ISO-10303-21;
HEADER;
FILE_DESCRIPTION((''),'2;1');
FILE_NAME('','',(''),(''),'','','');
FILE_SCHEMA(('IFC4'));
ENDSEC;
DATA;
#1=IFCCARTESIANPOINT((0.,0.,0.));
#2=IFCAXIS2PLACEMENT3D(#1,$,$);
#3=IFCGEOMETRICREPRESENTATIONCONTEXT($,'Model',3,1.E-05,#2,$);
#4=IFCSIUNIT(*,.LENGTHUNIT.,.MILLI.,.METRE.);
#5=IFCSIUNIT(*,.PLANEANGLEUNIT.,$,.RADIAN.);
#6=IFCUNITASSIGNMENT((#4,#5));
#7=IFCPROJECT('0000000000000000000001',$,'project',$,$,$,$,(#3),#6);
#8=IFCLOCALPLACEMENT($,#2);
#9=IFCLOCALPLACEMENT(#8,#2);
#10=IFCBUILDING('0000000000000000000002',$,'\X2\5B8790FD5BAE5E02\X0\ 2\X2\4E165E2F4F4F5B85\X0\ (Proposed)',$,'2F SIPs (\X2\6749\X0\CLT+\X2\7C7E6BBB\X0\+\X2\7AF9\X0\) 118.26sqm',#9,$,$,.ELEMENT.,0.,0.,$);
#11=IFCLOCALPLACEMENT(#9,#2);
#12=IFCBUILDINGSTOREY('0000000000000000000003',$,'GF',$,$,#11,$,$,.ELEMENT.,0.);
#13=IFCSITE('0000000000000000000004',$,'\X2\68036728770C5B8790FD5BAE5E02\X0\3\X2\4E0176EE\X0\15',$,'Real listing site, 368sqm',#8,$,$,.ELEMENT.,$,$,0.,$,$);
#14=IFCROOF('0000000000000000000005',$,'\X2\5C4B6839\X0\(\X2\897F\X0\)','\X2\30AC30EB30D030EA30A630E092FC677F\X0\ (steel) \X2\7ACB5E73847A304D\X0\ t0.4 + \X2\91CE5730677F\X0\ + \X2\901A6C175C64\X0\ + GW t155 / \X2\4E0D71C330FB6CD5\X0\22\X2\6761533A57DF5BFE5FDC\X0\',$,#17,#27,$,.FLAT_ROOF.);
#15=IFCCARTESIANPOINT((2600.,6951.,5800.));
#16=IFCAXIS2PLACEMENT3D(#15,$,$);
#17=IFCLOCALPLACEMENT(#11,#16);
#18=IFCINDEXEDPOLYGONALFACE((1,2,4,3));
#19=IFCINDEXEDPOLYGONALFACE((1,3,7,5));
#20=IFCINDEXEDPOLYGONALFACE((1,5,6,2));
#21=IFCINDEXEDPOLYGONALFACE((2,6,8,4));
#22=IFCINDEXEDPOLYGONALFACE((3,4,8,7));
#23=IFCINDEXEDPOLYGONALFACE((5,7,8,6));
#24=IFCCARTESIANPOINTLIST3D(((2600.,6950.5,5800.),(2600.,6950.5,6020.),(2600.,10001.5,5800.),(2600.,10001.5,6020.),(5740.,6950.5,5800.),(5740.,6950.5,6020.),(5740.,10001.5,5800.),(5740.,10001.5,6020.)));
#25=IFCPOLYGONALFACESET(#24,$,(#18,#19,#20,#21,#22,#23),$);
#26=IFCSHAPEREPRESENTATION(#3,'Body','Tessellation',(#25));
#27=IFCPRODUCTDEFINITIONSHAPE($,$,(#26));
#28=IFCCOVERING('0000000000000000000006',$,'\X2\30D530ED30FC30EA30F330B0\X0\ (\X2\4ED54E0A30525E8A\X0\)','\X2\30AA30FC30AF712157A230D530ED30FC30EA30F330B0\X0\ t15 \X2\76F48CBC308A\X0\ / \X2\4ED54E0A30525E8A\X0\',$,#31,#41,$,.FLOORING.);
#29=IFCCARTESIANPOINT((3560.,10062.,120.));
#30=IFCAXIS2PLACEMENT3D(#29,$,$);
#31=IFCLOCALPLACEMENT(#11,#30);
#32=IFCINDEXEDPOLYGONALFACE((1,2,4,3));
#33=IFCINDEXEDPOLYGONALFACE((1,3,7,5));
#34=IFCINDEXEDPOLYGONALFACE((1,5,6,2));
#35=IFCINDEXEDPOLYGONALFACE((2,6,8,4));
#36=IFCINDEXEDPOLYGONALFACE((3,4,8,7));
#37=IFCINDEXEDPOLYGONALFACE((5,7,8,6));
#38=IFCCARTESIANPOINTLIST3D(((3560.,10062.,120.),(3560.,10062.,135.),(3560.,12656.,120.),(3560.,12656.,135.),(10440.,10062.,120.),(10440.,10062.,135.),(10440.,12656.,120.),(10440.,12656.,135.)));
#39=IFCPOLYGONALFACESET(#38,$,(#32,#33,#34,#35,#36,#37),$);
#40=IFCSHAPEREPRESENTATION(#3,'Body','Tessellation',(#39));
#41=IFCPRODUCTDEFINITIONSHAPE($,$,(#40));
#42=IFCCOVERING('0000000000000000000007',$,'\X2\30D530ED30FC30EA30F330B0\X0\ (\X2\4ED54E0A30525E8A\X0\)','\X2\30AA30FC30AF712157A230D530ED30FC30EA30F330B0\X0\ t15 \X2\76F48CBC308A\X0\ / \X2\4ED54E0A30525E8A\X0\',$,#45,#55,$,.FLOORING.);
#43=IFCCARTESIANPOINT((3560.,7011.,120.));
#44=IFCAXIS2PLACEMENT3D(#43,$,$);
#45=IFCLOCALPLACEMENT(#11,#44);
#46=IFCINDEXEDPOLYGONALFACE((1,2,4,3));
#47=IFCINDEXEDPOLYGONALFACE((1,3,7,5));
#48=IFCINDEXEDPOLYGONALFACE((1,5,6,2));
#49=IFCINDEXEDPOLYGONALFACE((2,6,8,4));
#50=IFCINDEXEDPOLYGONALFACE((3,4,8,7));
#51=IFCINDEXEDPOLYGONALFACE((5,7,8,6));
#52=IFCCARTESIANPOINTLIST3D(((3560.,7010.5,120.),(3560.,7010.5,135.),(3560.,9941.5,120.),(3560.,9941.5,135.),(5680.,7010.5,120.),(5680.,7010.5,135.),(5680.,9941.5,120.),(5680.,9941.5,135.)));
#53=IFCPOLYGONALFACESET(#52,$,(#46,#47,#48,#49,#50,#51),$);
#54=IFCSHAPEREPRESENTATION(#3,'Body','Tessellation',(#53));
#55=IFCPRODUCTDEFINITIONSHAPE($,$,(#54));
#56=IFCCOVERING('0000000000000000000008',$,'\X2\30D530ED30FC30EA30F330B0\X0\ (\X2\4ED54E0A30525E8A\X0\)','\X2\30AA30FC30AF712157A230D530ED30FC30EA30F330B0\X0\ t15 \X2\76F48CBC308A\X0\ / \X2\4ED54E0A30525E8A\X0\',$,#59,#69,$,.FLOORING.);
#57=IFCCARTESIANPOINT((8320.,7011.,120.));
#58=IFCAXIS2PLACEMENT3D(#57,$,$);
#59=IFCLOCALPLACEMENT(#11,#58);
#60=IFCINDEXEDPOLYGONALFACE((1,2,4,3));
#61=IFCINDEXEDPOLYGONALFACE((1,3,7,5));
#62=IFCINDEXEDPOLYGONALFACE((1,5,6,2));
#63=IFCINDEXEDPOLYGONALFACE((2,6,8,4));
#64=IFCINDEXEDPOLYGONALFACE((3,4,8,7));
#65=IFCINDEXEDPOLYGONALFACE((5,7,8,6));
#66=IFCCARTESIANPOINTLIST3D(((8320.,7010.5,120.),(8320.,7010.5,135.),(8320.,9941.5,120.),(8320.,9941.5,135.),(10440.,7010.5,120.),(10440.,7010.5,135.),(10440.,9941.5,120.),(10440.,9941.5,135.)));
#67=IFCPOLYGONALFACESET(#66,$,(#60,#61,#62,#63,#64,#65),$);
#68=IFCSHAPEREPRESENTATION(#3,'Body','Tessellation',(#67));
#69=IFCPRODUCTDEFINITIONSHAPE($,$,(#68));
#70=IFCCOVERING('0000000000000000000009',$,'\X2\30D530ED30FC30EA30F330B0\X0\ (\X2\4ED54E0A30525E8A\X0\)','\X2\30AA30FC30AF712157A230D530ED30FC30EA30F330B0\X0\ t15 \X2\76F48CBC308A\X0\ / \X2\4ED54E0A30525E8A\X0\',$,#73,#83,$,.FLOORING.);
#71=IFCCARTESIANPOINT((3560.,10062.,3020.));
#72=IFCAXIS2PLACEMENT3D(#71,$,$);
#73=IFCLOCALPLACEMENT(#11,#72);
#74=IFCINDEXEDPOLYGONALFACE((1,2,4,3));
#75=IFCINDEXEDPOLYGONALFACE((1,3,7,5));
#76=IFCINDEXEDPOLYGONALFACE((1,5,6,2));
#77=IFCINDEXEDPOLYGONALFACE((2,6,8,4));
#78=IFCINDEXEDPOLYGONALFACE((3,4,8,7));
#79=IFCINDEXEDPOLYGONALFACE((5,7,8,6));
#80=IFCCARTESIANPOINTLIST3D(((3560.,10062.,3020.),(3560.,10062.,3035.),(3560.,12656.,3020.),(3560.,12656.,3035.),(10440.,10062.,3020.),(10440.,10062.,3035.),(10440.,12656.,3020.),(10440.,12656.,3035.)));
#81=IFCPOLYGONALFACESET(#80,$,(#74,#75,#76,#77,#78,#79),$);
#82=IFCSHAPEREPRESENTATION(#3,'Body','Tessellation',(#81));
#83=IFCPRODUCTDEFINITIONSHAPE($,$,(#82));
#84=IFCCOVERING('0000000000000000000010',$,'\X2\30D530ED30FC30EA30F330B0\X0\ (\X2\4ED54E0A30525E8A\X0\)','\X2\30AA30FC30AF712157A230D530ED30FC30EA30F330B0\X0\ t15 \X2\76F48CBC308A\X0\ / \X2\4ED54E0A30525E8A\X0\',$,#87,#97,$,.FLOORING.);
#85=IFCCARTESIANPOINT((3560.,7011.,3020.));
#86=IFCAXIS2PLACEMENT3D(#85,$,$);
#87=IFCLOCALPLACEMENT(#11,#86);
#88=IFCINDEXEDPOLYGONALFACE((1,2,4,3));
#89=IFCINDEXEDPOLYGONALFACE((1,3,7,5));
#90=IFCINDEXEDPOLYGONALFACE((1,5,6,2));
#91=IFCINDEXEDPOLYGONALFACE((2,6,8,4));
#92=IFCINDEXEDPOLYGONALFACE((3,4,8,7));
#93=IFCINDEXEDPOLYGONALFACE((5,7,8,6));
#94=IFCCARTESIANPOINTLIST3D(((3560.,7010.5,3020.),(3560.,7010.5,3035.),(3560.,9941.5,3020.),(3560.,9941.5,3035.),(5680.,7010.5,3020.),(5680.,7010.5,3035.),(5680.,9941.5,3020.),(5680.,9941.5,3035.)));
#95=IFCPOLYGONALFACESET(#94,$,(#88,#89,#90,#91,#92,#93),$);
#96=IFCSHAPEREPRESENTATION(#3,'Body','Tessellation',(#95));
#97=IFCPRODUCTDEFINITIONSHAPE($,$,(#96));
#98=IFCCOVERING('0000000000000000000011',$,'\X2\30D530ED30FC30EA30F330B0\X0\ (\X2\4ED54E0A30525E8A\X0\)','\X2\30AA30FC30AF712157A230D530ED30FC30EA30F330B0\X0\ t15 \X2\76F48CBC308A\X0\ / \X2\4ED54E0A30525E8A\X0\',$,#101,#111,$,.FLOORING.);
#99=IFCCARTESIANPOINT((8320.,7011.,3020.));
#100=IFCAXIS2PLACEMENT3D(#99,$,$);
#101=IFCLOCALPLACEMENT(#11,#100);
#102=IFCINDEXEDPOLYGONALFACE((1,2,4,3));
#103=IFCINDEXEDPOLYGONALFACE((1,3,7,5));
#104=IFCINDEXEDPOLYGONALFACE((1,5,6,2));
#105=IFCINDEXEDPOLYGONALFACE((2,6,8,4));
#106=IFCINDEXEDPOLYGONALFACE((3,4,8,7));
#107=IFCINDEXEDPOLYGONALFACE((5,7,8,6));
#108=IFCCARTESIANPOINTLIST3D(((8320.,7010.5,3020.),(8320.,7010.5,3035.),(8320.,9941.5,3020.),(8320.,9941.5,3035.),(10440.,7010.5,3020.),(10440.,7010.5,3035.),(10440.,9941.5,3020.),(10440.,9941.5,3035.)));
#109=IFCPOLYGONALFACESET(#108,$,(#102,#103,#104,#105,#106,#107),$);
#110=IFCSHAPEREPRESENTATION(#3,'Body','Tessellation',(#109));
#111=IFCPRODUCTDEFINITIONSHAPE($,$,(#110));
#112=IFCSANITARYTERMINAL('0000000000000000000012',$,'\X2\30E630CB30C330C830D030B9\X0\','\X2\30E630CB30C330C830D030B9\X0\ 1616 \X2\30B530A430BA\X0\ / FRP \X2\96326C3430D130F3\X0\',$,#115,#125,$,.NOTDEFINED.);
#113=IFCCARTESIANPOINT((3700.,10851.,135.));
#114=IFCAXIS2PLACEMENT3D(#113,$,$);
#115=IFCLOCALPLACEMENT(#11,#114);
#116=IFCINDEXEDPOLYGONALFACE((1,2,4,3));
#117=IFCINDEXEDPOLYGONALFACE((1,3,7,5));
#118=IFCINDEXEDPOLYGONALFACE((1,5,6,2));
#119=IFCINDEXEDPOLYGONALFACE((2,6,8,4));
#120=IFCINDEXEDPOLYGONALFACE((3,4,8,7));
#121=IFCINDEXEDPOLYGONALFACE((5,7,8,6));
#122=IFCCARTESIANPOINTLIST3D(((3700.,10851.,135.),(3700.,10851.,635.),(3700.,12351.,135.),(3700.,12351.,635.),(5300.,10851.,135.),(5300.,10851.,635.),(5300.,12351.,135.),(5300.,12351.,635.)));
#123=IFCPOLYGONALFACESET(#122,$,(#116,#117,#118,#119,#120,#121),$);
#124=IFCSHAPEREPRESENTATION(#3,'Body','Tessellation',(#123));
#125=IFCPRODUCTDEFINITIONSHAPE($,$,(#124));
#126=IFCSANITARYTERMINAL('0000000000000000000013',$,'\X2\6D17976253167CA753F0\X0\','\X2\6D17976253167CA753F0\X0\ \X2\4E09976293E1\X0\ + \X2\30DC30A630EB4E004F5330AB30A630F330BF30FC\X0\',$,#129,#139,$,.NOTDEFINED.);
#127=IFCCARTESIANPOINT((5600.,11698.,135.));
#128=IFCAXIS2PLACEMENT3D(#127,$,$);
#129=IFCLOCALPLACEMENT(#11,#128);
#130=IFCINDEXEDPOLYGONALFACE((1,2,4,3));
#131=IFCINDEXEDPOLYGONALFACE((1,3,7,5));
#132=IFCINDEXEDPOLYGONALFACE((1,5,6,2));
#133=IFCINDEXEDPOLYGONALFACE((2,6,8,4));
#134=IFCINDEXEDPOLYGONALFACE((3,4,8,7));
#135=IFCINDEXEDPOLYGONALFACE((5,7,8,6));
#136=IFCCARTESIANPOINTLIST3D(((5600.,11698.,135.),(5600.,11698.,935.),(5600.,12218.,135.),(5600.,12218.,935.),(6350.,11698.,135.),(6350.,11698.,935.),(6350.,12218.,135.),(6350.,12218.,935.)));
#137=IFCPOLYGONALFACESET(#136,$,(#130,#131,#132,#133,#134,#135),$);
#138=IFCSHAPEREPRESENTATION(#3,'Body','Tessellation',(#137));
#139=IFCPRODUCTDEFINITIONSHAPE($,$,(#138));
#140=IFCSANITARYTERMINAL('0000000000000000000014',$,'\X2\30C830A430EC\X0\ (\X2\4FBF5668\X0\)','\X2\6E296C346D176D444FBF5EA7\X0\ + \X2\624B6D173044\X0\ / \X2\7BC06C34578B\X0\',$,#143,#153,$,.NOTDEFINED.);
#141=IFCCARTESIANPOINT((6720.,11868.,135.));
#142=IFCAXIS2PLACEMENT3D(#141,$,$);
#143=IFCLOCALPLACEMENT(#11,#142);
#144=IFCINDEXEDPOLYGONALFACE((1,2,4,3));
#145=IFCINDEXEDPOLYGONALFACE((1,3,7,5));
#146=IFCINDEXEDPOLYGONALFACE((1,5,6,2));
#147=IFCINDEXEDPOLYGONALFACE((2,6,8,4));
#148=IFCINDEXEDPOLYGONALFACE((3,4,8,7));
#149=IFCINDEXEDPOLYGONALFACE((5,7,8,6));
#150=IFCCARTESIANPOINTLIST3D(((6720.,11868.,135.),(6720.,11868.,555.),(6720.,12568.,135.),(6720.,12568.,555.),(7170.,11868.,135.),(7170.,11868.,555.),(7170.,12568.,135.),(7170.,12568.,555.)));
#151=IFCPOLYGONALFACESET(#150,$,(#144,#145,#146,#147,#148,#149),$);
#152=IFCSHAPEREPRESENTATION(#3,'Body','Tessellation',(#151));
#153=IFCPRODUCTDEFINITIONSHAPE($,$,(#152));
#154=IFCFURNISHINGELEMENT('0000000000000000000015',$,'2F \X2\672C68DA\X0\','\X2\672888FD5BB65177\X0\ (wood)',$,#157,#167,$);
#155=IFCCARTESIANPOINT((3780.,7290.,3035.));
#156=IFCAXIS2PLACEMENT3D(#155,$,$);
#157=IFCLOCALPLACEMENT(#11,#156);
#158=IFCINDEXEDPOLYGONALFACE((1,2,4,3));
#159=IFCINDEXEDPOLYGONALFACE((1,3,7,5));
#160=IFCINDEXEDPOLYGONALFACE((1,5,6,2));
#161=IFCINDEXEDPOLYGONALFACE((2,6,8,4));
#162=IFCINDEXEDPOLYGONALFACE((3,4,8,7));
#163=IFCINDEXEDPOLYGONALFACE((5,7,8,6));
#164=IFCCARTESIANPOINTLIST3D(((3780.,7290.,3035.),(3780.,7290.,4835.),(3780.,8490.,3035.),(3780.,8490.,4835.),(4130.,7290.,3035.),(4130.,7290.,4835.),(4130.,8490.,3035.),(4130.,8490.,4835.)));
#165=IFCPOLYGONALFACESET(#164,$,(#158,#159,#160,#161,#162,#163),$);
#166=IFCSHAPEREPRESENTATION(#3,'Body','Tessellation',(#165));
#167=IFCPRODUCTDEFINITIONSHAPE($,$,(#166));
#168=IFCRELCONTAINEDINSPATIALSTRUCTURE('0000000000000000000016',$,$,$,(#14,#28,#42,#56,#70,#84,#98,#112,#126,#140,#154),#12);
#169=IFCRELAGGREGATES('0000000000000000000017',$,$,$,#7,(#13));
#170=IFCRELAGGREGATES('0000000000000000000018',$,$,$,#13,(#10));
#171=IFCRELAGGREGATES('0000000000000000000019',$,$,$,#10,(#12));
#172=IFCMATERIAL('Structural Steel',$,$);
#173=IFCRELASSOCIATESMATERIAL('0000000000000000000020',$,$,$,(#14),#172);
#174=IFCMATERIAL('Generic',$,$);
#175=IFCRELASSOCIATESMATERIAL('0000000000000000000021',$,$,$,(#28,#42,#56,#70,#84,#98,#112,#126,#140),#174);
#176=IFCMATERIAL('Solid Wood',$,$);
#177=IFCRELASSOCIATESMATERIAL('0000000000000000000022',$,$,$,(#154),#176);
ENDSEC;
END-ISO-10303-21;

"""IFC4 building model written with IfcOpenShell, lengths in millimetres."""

from ifc_helpers import new_model, si_unit, frame, frame_2d, origin, place, context, project, spatial, rectangle, extrude, material, element, save


model = new_model("IFC4")

# Units and contexts
model_context = context("Model", 3, precision=1e-05, world=origin())
ifc_project = project(units=[si_unit("LENGTHUNIT", "METRE", prefix="MILLI"), si_unit("PLANEANGLEUNIT", "RADIAN")], contexts=[model_context])

# Site, building, storey
site_placement = place(None, origin())
site = spatial("IfcSite", under=ifc_project, at=site_placement, Name="栃木県宇都宮市3丁目15", ObjectType="Real listing site, 368sqm", CompositionType="ELEMENT", RefElevation=0.0)
building_placement = place(site_placement, origin())
building = spatial("IfcBuilding", under=site, at=building_placement, Name="宇都宮市 2世帯住宅 (Proposed)", ObjectType="2F SIPs (杉CLT+籾殻+竹) 118.26sqm", CompositionType="ELEMENT", ElevationOfRefHeight=0.0, ElevationOfTerrain=0.0)
storey_placement = place(building_placement, origin())
storey = spatial("IfcBuildingStorey", under=building, at=storey_placement, Name="GF", CompositionType="ELEMENT", Elevation=0.0)

# Shared definitions
ifc_material_1 = material(Name="Solid Wood")

# Shared definitions
ifc_material_2 = material(Name="Generic")

# Roof
ifc_material_3 = material(Name="Structural Steel")
roof_1_placement = place(storey_placement, frame((2600.0, 6951.0, 5800.0)))
element("IfcRoof", 1, at=roof_1_placement, inside=storey, material=ifc_material_3, Name="屋根(西)", Description="ガルバリウム鋼板 (steel) 立平葺き t0.4 + 野地板 + 通気層 + GW t155 / 不燃・法22条区域対応", PredefinedType="FLAT_ROOF", context=model_context, shape_type="SweptSolid", body=[
    extrude(rectangle(XDim=3140.0, YDim=3051.0, at=frame_2d((1570.0, 1525.0))), frame((2600.0, 6951.0, 5800.0)), (0.0, 0.0, 1.0), 220.0),
])

# Coverings
covering_1_placement = place(storey_placement, frame((3560.0, 10062.0, 120.0)))
element("IfcCovering", 2, at=covering_1_placement, inside=storey, material=ifc_material_2, Name="フローリング (仕上げ床)", Description="オーク無垢フローリング t15 直貼り / 仕上げ床", PredefinedType="FLOORING", context=model_context, shape_type="SweptSolid", body=[
    extrude(rectangle(XDim=6880.0, YDim=2594.0, at=frame_2d((3440.0, 1297.0))), frame((3560.0, 10062.0, 120.0)), (0.0, 0.0, 1.0), 15.0),
])
covering_2_placement = place(storey_placement, frame((3560.0, 7011.0, 120.0)))
element("IfcCovering", 3, at=covering_2_placement, inside=storey, material=ifc_material_2, Name="フローリング (仕上げ床)", Description="オーク無垢フローリング t15 直貼り / 仕上げ床", PredefinedType="FLOORING", context=model_context, shape_type="SweptSolid", body=[
    extrude(rectangle(XDim=2120.0, YDim=2931.0, at=frame_2d((1060.0, 1465.0))), frame((3560.0, 7011.0, 120.0)), (0.0, 0.0, 1.0), 15.0),
])
covering_3_placement = place(storey_placement, frame((8320.0, 7011.0, 120.0)))
element("IfcCovering", 4, at=covering_3_placement, inside=storey, material=ifc_material_2, Name="フローリング (仕上げ床)", Description="オーク無垢フローリング t15 直貼り / 仕上げ床", PredefinedType="FLOORING", context=model_context, shape_type="SweptSolid", body=[
    extrude(rectangle(XDim=2120.0, YDim=2931.0, at=frame_2d((1060.0, 1465.0))), frame((8320.0, 7011.0, 120.0)), (0.0, 0.0, 1.0), 15.0),
])
covering_4_placement = place(storey_placement, frame((3560.0, 10062.0, 3020.0)))
element("IfcCovering", 5, at=covering_4_placement, inside=storey, material=ifc_material_2, Name="フローリング (仕上げ床)", Description="オーク無垢フローリング t15 直貼り / 仕上げ床", PredefinedType="FLOORING", context=model_context, shape_type="SweptSolid", body=[
    extrude(rectangle(XDim=6880.0, YDim=2594.0, at=frame_2d((3440.0, 1297.0))), frame((3560.0, 10062.0, 3020.0)), (0.0, 0.0, 1.0), 15.0),
])
covering_5_placement = place(storey_placement, frame((3560.0, 7011.0, 3020.0)))
element("IfcCovering", 6, at=covering_5_placement, inside=storey, material=ifc_material_2, Name="フローリング (仕上げ床)", Description="オーク無垢フローリング t15 直貼り / 仕上げ床", PredefinedType="FLOORING", context=model_context, shape_type="SweptSolid", body=[
    extrude(rectangle(XDim=2120.0, YDim=2931.0, at=frame_2d((1060.0, 1465.0))), frame((3560.0, 7011.0, 3020.0)), (0.0, 0.0, 1.0), 15.0),
])
covering_6_placement = place(storey_placement, frame((8320.0, 7011.0, 3020.0)))
element("IfcCovering", 7, at=covering_6_placement, inside=storey, material=ifc_material_2, Name="フローリング (仕上げ床)", Description="オーク無垢フローリング t15 直貼り / 仕上げ床", PredefinedType="FLOORING", context=model_context, shape_type="SweptSolid", body=[
    extrude(rectangle(XDim=2120.0, YDim=2931.0, at=frame_2d((1060.0, 1465.0))), frame((8320.0, 7011.0, 3020.0)), (0.0, 0.0, 1.0), 15.0),
])

# Sanitary terminals
sanitary_terminal_1_placement = place(storey_placement, frame((3700.0, 10851.0, 135.0)))
element("IfcSanitaryTerminal", 8, at=sanitary_terminal_1_placement, inside=storey, material=ifc_material_2, Name="ユニットバス", Description="ユニットバス 1616 サイズ / FRP 防水パン", PredefinedType="NOTDEFINED", context=model_context, shape_type="SweptSolid", body=[
    extrude(rectangle(XDim=1600.0, YDim=1500.0, at=frame_2d((800.0, 750.0))), frame((3700.0, 10851.0, 135.0)), (0.0, 0.0, 1.0), 500.0),
])
sanitary_terminal_2_placement = place(storey_placement, frame((5600.0, 11698.0, 135.0)))
element("IfcSanitaryTerminal", 9, at=sanitary_terminal_2_placement, inside=storey, material=ifc_material_2, Name="洗面化粧台", Description="洗面化粧台 三面鏡 + ボウル一体カウンター", PredefinedType="NOTDEFINED", context=model_context, shape_type="SweptSolid", body=[
    extrude(rectangle(XDim=750.0, YDim=520.0, at=frame_2d((375.0, 260.0))), frame((5600.0, 11698.0, 135.0)), (0.0, 0.0, 1.0), 800.0),
])
sanitary_terminal_3_placement = place(storey_placement, frame((6720.0, 11868.0, 135.0)))
element("IfcSanitaryTerminal", 10, at=sanitary_terminal_3_placement, inside=storey, material=ifc_material_2, Name="トイレ (便器)", Description="温水洗浄便座 + 手洗い / 節水型", PredefinedType="NOTDEFINED", context=model_context, shape_type="SweptSolid", body=[
    extrude(rectangle(XDim=450.0, YDim=700.0, at=frame_2d((225.0, 350.0))), frame((6720.0, 11868.0, 135.0)), (0.0, 0.0, 1.0), 420.0),
])

# Furnishing element
furnishing_placement = place(storey_placement, frame((3780.0, 7290.0, 3035.0)))
element("IfcFurnishingElement", 11, at=furnishing_placement, inside=storey, material=ifc_material_1, Name="2F 本棚", Description="木製家具 (wood)", context=model_context, shape_type="SweptSolid", body=[
    extrude(rectangle(XDim=350.0, YDim=1200.0, at=frame_2d((175.0, 600.0))), frame((3780.0, 7290.0, 3035.0)), (0.0, 0.0, 1.0), 1800.0),
])

save(model, "model.ifc")
